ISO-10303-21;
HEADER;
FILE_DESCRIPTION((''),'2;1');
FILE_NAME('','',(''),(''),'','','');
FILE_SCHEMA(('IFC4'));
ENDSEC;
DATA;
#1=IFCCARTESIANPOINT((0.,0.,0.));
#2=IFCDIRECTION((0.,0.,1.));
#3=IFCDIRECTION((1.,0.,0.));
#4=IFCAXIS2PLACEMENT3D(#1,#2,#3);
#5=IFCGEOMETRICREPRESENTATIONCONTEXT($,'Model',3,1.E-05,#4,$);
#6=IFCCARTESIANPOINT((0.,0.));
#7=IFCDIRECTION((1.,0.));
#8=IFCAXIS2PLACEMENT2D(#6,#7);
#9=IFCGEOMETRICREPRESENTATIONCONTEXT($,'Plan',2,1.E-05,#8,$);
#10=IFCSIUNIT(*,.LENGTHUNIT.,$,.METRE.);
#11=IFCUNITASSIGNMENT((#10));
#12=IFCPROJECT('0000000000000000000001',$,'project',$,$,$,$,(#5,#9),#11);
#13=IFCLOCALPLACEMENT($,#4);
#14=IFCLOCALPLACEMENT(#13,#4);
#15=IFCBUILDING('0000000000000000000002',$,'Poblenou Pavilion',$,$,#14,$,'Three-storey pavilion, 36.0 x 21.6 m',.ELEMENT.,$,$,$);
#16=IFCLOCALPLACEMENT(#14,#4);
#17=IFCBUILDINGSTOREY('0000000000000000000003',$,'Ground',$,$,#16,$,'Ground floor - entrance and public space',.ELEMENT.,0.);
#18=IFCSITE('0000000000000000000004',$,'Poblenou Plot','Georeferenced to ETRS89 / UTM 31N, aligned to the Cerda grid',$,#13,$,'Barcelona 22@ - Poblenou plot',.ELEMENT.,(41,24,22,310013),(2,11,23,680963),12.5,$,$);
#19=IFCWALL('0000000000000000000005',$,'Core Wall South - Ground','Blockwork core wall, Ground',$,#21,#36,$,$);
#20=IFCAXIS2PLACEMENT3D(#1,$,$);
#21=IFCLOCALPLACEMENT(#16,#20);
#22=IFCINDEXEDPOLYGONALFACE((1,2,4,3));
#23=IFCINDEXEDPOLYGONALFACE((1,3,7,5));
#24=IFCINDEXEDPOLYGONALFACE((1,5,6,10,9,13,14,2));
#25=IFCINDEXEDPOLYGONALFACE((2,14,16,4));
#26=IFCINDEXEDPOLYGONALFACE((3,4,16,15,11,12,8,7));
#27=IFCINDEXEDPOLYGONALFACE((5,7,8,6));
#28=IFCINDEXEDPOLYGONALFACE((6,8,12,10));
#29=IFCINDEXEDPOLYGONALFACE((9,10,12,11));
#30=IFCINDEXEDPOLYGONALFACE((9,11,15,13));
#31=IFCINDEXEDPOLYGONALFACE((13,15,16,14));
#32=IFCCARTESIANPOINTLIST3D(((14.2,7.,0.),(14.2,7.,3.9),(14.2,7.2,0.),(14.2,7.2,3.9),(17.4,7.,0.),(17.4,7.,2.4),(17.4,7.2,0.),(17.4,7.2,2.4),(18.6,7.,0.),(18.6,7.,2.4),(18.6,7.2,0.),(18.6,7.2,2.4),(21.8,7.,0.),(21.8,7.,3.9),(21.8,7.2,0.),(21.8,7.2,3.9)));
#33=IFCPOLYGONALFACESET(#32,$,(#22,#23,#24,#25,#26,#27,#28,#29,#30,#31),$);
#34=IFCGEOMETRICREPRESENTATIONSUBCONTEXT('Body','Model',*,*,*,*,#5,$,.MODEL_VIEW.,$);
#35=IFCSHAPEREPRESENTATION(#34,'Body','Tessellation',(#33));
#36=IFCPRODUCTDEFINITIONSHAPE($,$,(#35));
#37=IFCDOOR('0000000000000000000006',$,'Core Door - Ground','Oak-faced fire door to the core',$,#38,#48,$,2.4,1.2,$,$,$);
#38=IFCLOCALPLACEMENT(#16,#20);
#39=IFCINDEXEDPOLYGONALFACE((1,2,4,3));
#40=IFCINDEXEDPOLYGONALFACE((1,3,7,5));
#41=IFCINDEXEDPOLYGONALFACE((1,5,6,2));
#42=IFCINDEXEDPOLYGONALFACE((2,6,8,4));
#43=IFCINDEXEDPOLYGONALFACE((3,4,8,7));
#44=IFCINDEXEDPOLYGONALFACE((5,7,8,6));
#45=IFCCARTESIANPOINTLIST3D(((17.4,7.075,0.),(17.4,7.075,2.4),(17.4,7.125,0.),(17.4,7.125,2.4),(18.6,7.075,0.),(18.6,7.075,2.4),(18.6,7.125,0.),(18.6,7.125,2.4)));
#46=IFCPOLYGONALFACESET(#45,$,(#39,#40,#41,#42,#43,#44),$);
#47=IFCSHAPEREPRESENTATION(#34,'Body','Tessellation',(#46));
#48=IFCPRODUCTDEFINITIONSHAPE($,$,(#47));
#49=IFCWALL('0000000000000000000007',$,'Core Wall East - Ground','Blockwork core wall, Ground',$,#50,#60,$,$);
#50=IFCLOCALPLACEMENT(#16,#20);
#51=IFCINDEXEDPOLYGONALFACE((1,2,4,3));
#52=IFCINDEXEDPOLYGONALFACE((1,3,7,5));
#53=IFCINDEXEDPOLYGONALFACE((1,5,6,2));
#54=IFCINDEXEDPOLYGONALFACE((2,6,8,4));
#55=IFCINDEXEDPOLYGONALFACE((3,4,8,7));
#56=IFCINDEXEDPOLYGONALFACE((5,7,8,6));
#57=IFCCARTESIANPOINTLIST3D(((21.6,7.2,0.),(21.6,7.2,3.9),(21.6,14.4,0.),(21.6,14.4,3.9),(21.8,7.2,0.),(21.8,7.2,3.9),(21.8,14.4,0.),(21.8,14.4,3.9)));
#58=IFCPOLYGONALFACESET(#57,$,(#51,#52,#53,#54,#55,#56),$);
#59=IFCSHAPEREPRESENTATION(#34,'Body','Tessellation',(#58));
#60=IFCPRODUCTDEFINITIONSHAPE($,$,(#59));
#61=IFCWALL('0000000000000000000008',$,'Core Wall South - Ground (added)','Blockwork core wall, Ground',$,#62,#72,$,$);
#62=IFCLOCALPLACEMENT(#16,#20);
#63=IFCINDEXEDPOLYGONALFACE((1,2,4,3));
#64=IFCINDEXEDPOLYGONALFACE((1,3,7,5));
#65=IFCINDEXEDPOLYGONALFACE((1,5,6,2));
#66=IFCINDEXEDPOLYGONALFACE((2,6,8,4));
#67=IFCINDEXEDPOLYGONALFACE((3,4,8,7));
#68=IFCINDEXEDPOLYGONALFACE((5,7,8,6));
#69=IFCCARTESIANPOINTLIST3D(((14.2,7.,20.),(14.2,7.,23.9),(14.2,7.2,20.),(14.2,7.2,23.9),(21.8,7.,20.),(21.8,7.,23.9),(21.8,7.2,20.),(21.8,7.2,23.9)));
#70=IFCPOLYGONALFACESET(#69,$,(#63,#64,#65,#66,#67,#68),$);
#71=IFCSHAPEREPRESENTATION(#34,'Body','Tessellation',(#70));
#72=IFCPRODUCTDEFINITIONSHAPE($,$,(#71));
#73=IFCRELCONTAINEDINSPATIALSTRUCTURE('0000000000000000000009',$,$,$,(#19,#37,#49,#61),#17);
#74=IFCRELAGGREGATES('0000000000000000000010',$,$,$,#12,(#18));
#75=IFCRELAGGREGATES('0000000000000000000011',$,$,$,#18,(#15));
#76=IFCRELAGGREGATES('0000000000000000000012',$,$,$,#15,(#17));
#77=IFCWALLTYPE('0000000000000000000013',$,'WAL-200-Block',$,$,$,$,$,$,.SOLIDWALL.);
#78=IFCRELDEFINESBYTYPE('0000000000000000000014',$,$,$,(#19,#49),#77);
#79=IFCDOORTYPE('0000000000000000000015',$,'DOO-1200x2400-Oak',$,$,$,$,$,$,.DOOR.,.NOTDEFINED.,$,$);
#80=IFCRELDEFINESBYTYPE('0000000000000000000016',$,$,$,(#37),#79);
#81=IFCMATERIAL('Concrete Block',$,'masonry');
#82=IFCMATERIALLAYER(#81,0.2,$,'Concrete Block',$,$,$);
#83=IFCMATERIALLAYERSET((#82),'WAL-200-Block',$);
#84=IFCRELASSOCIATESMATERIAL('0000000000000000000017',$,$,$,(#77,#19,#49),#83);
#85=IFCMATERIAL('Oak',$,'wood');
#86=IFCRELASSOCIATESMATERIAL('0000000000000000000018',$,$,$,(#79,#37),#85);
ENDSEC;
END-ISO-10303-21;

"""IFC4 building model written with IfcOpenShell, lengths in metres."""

from ifc_helpers import new_model, si_unit, frame, origin_with_axes, origin_2d_with_axis, place, context, subcontext, project, spatial, line, indexed_curve, outline, extrude, material, layer, layer_set, layer_usage, type_object, element, fill, save


model = new_model("IFC4")

# Units and contexts
model_context = context("Model", 3, precision=1e-05, world=origin_with_axes())
plan_context = context("Plan", 2, precision=1e-05, world=origin_2d_with_axis())
body_context = subcontext(model_context, "Body", "Model", "MODEL_VIEW")
ifc_project = project(units=[si_unit("LENGTHUNIT", "METRE")], contexts=[model_context, plan_context])

# Site, building, storey
site_placement = place(None, origin_with_axes())
site = spatial("IfcSite", under=ifc_project, at=site_placement, Name="Poblenou Plot", Description="Georeferenced to ETRS89 / UTM 31N, aligned to the Cerda grid", LongName="Barcelona 22@ - Poblenou plot", CompositionType="ELEMENT", RefLatitude=(41, 24, 22, 310013), RefLongitude=(2, 11, 23, 680963), RefElevation=12.5)
building_placement = place(site_placement, origin_with_axes())
building = spatial("IfcBuilding", under=site, at=building_placement, Name="Poblenou Pavilion", LongName="Three-storey pavilion, 36.0 x 21.6 m", CompositionType="ELEMENT")
storey_placement = place(building_placement, origin_with_axes())
storey = spatial("IfcBuildingStorey", under=building, at=storey_placement, Name="Ground", LongName="Ground floor - entrance and public space", CompositionType="ELEMENT", Elevation=0.0)

# Wall, opening, door
ifc_material_1 = material(Name="Concrete Block", Category="masonry")
ifc_layer_1 = layer(ifc_material_1, 0.2, Name="Concrete Block")
ifc_layer_set_1 = layer_set([ifc_layer_1], Name="WAL-200-Block")
ifc_layer_usage_1 = layer_usage(ifc_layer_set_1, "AXIS2", "POSITIVE", 0.0)
wall_type = type_object("IfcWallType", Name="WAL-200-Block", PredefinedType="SOLIDWALL", material=ifc_layer_set_1)
wall_1_placement = place(storey_placement, frame((21.8, 7.2, 0.0), z_axis=(0.0, 0.0, 1.0), x_axis=(-1.0, 0.0, 0.0)))
wall_1 = element("IfcWall", 1, at=wall_1_placement, inside=storey, type_object=wall_type, material=ifc_layer_usage_1, Name="Core Wall South - Ground", Description="Blockwork core wall, Ground", context=body_context, shape_type="SweptSolid", body=[
    extrude(outline(indexed_curve([(0.0, 0.0), (7.6, 0.0), (7.6, 0.2), (0.0, 0.2)], segments=[line(1, 2, 3, 4, 1)])), origin_with_axes(), (0.0, 0.0, 1.0), 3.9),
])
opening_placement = place(wall_1_placement, frame((4.4, 0.21, 0.0), z_axis=(0.0, 0.0, 1.0), x_axis=(-1.0, 0.0, 0.0)))
opening = element("IfcOpeningElement", 2, at=opening_placement, cuts=wall_1, PredefinedType="OPENING", context=body_context, shape_type="SweptSolid", body=[
    extrude(outline(indexed_curve([(0.0, 0.0), (1.2, 0.0), (1.2, 0.22), (0.0, 0.22)], segments=[line(1, 2, 3, 4, 1)])), origin_with_axes(), (0.0, 0.0, 1.0), 2.4),
])
ifc_material_2 = material(Name="Oak", Category="wood")
door_type = type_object("IfcDoorType", Name="DOO-1200x2400-Oak", OperationType="NOTDEFINED", PredefinedType="DOOR", material=ifc_material_2)
door_placement = place(storey_placement, frame((17.4, 7.075, 0.0), z_axis=(0.0, 0.0, 1.0), x_axis=(1.0, 0.0, 0.0)))
door = element("IfcDoor", 3, at=door_placement, inside=storey, type_object=door_type, material=ifc_material_2, Name="Core Door - Ground", Description="Oak-faced fire door to the core", OverallHeight=2.4, OverallWidth=1.2, context=body_context, shape_type="SweptSolid", body=[
    extrude(outline(indexed_curve([(0.0, 0.0), (1.2, 0.0), (1.2, 0.05), (0.0, 0.05)], segments=[line(1, 2, 3, 4, 1)])), origin_with_axes(), (0.0, 0.0, 1.0), 2.4),
])
fill(opening, door)

# Walls
ifc_layer_usage_2 = layer_usage(ifc_layer_set_1, "AXIS2", "POSITIVE", 0.0)
wall_2_placement = place(storey_placement, frame((21.6, 14.4, 0.0), z_axis=(0.0, 0.0, 1.0), x_axis=(0.0, -1.0, 0.0)))
element("IfcWall", 4, at=wall_2_placement, inside=storey, type_object=wall_type, material=ifc_layer_usage_2, Name="Core Wall East - Ground", Description="Blockwork core wall, Ground", context=body_context, shape_type="SweptSolid", body=[
    extrude(outline(indexed_curve([(0.0, 0.0), (7.2, 0.0), (7.2, 0.2), (0.0, 0.2)], segments=[line(1, 2, 3, 4, 1)])), origin_with_axes(), (0.0, 0.0, 1.0), 3.9),
])
wall_3_placement = place(storey_placement, frame((21.8, 7.2, 20.0), z_axis=(0.0, 0.0, 1.0), x_axis=(-1.0, 0.0, 0.0)))
element("IfcWall", 5, at=wall_3_placement, inside=storey, Name="Core Wall South - Ground (added)", Description="Blockwork core wall, Ground", context=body_context, shape_type="SweptSolid", body=[
    extrude(outline(indexed_curve([(0.0, 0.0), (7.6, 0.0), (7.6, 0.2), (0.0, 0.2)], segments=[line(1, 2, 3, 4, 1)])), origin_with_axes(), (0.0, 0.0, 1.0), 3.9),
])

save(model, "model.ifc")
